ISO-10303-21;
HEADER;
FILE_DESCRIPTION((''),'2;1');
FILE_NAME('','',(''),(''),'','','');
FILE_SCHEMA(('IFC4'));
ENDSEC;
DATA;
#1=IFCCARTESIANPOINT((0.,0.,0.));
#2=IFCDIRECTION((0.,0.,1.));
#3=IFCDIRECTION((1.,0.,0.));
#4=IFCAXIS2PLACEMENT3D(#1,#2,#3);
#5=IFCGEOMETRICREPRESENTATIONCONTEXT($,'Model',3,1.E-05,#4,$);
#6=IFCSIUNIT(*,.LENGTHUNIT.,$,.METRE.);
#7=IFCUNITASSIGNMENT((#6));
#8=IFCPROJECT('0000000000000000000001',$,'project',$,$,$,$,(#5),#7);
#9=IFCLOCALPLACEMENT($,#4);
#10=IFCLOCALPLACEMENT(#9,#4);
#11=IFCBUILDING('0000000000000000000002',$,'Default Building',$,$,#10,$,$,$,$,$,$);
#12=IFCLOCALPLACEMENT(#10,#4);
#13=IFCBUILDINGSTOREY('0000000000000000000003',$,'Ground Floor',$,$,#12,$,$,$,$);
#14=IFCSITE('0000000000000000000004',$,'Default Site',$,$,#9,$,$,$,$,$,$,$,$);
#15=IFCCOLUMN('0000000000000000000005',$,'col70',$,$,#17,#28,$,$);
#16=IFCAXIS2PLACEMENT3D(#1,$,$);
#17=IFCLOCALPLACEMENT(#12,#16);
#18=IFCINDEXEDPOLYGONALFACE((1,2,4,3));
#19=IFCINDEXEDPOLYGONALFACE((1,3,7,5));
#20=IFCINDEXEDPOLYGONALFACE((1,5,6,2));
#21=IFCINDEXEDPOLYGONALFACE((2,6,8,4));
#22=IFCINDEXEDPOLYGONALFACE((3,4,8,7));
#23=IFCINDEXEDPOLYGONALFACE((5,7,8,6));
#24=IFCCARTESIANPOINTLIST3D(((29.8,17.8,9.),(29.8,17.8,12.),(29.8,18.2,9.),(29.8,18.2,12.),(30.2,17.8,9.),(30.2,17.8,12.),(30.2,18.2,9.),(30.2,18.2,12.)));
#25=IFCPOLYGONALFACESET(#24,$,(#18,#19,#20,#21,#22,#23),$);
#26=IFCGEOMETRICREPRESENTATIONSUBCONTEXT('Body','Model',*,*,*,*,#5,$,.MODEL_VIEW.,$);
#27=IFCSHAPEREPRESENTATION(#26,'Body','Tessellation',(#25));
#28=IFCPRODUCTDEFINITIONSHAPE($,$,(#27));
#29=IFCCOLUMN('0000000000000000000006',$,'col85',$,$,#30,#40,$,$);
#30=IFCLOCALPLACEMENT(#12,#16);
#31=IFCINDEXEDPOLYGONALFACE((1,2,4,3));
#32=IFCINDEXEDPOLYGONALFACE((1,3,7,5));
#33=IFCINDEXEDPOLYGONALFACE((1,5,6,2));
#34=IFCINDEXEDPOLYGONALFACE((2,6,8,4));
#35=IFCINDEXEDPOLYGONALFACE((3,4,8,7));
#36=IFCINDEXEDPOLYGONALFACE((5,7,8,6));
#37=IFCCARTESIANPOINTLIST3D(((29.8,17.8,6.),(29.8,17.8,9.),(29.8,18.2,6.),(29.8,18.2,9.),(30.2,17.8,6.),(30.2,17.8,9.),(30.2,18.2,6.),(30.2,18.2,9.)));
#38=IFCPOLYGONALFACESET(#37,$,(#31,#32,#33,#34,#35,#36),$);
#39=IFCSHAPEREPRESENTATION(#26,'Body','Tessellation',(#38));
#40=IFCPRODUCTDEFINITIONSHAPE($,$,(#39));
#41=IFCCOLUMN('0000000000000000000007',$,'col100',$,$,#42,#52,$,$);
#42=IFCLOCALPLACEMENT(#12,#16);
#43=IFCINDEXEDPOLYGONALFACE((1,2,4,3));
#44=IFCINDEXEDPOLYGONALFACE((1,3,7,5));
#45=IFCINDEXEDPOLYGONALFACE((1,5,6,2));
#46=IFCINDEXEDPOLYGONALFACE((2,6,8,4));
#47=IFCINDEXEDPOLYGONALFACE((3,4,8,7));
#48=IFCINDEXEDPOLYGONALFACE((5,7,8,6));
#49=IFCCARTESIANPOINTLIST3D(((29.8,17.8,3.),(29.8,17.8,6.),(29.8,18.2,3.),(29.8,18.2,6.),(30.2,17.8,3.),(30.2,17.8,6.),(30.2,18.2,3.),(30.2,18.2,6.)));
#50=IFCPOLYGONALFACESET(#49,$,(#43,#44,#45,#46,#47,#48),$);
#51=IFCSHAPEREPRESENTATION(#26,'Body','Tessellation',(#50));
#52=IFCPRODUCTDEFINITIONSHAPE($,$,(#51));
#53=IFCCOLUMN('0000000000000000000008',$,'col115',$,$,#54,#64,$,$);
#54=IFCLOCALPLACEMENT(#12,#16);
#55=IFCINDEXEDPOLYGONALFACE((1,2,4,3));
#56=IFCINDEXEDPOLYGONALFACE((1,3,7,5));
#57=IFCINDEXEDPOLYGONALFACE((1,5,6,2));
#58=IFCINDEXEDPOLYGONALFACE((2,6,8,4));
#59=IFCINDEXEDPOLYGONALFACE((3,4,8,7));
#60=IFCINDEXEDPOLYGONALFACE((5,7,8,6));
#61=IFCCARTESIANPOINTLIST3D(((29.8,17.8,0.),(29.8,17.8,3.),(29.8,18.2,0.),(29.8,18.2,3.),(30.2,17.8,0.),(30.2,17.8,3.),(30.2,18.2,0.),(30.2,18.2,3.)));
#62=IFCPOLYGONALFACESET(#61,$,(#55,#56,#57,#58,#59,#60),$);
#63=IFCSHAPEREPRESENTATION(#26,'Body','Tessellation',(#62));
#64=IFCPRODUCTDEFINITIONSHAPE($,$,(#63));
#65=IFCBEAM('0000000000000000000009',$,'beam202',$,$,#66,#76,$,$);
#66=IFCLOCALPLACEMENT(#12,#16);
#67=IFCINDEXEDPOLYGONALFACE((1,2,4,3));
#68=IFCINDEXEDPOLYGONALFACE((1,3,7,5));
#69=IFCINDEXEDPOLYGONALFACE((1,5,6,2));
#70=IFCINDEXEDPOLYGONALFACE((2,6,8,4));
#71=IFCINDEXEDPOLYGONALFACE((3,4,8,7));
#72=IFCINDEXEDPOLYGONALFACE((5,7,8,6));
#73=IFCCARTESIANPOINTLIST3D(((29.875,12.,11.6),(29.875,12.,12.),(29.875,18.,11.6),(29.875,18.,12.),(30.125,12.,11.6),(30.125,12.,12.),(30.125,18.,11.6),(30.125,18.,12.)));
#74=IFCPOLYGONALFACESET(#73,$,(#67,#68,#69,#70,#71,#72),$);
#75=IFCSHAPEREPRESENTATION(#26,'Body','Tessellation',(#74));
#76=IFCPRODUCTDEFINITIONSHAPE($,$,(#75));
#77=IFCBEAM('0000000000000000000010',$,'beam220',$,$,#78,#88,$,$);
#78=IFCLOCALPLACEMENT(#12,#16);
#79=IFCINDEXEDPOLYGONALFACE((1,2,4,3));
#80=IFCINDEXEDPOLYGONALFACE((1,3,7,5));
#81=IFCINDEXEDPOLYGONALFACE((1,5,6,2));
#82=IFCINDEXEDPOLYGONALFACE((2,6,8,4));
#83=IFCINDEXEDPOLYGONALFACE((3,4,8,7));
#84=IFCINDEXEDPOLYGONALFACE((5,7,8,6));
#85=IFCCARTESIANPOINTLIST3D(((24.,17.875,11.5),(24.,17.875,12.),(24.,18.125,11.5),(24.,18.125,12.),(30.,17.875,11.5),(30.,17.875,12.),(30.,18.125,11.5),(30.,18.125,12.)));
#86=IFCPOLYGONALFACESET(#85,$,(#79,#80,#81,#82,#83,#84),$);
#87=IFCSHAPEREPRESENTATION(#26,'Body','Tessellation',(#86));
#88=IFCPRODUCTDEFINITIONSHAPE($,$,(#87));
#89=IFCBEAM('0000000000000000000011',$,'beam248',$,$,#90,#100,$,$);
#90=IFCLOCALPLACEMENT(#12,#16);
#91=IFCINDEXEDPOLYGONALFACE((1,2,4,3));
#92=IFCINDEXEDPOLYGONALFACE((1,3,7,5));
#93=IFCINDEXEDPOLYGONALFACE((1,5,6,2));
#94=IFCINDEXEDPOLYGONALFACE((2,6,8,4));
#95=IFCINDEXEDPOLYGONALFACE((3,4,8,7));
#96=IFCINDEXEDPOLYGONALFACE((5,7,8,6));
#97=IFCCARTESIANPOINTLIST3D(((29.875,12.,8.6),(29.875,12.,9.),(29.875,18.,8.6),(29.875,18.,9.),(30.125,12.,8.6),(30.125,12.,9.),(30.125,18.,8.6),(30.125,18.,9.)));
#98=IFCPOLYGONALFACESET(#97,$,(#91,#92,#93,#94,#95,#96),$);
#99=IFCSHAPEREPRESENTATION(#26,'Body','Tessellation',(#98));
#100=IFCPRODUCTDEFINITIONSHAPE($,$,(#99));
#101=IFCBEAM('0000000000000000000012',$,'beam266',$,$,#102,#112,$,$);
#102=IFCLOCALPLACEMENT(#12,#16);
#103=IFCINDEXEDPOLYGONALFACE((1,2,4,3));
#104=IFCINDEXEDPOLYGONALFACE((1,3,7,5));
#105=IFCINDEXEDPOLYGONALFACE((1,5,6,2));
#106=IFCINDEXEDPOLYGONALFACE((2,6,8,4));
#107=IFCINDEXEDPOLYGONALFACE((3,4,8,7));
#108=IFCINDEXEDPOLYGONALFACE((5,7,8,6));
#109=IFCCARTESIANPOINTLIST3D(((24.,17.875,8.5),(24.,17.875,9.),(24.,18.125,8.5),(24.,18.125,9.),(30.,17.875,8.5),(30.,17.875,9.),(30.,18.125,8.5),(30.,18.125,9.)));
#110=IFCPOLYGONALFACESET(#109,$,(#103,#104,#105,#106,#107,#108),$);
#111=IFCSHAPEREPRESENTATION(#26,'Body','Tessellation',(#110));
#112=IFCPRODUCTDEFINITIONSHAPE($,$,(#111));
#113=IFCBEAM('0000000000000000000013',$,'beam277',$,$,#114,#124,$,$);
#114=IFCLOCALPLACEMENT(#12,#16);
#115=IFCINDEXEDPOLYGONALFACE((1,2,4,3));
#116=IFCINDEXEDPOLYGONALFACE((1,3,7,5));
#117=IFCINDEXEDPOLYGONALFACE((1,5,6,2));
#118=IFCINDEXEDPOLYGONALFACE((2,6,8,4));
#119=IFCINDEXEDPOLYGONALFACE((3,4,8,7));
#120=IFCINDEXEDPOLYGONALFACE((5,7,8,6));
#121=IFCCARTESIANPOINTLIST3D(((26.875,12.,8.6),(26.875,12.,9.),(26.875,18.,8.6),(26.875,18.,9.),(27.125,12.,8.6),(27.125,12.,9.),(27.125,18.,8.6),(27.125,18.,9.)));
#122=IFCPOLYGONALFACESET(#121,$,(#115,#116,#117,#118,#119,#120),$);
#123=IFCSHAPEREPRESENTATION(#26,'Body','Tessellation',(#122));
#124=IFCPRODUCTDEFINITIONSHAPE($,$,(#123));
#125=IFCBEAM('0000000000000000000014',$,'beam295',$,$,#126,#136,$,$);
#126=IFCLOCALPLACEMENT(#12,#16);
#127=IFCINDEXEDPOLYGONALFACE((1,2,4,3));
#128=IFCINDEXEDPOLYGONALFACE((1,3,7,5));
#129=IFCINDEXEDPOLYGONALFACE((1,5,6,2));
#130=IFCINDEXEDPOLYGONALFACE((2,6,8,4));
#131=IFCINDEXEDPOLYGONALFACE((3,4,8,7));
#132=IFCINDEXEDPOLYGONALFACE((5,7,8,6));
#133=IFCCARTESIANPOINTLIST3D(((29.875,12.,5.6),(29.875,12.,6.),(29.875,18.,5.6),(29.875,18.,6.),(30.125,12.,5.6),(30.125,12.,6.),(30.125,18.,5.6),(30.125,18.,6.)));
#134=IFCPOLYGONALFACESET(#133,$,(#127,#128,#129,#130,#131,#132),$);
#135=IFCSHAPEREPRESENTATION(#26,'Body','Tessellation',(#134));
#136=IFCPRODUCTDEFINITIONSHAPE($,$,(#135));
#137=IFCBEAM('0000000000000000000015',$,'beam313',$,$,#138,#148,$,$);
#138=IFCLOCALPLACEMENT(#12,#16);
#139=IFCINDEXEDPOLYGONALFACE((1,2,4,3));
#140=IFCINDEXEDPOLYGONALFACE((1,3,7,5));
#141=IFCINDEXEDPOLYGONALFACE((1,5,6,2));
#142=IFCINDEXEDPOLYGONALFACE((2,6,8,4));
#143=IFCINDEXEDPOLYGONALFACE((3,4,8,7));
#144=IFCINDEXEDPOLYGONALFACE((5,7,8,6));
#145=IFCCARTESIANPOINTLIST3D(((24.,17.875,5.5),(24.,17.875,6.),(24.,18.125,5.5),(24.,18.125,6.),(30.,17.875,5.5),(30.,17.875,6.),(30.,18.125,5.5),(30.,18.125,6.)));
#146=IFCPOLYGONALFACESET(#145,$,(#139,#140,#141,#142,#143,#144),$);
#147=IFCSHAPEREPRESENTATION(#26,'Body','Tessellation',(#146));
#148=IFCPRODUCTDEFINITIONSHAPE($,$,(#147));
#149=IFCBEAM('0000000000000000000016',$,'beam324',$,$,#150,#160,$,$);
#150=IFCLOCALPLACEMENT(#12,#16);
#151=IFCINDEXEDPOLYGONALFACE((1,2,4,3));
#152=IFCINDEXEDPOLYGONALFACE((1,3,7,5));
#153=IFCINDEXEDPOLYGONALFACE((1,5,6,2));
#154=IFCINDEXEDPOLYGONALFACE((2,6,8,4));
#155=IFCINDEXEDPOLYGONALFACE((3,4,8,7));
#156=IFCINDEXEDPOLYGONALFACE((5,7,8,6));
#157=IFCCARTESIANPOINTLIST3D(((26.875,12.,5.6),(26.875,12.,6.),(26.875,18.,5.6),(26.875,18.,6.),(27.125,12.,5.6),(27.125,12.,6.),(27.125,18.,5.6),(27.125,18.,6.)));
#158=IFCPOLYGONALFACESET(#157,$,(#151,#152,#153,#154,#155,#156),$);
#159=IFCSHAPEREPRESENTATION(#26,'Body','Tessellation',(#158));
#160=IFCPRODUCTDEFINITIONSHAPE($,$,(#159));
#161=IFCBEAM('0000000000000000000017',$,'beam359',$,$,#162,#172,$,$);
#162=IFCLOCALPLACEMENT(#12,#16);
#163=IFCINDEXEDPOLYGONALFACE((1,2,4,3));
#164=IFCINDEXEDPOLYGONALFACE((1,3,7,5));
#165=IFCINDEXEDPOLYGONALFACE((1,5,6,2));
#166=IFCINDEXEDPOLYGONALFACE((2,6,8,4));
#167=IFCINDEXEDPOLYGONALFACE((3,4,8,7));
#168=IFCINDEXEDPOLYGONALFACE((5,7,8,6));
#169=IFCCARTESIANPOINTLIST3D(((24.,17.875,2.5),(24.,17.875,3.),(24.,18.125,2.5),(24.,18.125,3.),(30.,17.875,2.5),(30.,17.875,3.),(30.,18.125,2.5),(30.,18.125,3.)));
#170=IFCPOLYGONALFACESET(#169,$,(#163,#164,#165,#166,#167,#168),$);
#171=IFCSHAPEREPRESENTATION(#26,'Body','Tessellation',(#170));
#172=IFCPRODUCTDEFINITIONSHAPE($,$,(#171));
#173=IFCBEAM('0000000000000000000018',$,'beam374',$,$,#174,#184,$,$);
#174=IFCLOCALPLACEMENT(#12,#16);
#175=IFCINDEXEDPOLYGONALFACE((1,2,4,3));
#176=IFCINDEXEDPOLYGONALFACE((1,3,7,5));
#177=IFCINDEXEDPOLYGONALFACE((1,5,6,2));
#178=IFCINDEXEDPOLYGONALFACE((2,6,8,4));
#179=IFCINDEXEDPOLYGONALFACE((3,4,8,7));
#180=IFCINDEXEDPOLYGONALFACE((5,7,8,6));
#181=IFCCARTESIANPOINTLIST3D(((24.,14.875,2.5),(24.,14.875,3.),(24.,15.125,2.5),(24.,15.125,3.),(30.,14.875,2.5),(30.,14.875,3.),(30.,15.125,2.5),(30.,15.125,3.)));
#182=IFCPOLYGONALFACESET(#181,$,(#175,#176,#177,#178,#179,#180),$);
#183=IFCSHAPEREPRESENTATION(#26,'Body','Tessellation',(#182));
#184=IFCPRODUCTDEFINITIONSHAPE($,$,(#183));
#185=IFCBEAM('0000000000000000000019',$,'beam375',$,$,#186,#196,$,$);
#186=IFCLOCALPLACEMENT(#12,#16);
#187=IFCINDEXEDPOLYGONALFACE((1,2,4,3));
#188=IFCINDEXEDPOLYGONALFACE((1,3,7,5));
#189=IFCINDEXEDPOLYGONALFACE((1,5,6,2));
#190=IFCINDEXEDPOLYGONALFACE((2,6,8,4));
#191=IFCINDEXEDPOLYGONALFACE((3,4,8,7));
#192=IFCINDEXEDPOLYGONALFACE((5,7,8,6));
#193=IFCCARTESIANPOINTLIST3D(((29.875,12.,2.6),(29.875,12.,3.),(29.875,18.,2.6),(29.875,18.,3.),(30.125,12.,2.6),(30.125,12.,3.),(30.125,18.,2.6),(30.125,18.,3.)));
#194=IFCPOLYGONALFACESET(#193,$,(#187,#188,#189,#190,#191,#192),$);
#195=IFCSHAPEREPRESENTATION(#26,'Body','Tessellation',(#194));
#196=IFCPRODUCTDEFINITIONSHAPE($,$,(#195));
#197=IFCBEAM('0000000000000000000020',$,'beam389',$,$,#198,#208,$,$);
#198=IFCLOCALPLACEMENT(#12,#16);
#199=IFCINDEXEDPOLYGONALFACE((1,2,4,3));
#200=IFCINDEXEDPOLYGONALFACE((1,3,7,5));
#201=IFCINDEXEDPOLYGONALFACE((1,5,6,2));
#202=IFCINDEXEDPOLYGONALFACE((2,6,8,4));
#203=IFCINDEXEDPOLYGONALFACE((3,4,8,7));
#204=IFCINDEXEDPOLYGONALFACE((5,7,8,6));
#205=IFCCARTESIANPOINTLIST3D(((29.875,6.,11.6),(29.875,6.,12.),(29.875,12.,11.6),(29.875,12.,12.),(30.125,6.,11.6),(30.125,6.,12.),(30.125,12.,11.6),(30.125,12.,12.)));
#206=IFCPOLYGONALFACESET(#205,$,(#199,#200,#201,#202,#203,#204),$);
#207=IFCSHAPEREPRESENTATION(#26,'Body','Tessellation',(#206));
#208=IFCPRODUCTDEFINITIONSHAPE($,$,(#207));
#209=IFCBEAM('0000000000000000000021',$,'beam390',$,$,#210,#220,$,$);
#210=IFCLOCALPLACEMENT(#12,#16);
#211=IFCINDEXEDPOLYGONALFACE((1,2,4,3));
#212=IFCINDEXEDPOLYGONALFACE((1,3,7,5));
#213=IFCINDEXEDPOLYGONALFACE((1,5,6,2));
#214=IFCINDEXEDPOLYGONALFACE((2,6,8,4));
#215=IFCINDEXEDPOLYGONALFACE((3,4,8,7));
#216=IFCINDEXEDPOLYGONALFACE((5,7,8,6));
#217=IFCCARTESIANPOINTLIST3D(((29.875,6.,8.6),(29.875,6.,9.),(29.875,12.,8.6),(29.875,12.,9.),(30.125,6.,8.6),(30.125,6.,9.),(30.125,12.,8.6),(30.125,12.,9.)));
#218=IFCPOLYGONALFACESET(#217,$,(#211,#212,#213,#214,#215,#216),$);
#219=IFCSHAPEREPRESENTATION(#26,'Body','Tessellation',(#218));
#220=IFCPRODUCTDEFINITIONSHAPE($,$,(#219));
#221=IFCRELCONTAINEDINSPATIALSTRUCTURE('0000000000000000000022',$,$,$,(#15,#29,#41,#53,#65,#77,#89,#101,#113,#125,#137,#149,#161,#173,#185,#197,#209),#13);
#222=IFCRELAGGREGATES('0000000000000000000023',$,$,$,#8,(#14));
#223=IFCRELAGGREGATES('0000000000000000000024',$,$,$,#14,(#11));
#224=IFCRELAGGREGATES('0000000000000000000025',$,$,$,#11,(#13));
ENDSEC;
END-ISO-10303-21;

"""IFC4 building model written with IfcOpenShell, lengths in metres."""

from ifc_helpers import new_model, si_unit, frame, origin_with_axes, place, context, subcontext, project, spatial, indexed_curve, outline, extrude, element, save


model = new_model("IFC4")

# Units and contexts
model_context = context("Model", 3, precision=1e-05, world=origin_with_axes())
body_context = subcontext(model_context, "Body", "Model", "MODEL_VIEW")
ifc_project = project(units=[si_unit("LENGTHUNIT", "METRE")], contexts=[model_context])

# Site, building, storey
site_placement = place(None, origin_with_axes())
site = spatial("IfcSite", under=ifc_project, at=site_placement, Name="Default Site")
building_placement = place(site_placement, origin_with_axes())
building = spatial("IfcBuilding", under=site, at=building_placement, Name="Default Building")
storey_placement = place(building_placement, origin_with_axes())
storey = spatial("IfcBuildingStorey", under=building, at=storey_placement, Name="Ground Floor")

# Columns
for number, where, z_axis, x_axis, name in (
    (1, (29.8, 17.8, 9.0), (0.0, 0.0, 1.0), (1.0, 0.0, 0.0), "col70"),
    (2, (29.8, 17.8, 6.0), (0.0, 0.0, 1.0), (1.0, 0.0, 0.0), "col85"),
    (3, (29.8, 17.8, 3.0), (0.0, 0.0, 1.0), (1.0, 0.0, 0.0), "col100"),
    (4, (29.8, 17.8, 0.0), (0.0, 0.0, 1.0), (1.0, 0.0, 0.0), "col115"),
):
    element("IfcColumn", number, at=place(storey_placement, frame(where, z_axis=z_axis, x_axis=x_axis)), inside=storey, Name=name, context=body_context, shape_type="SweptSolid", body=[
        extrude(outline(indexed_curve([(0.0, 0.0), (0.0, 0.4), (0.4, 0.4), (0.4, 0.0), (0.0, 0.0)], self_intersect=False)), origin_with_axes(), (0.0, 0.0, 1.0), 3.0),
    ])

# Beams
beam_1_placement = place(storey_placement, frame((30.125, 12.0, 11.6), z_axis=(0.0, 0.0, 1.0), x_axis=(0.0, 1.0, 0.0)))
element("IfcBeam", 5, at=beam_1_placement, inside=storey, Name="beam202", context=body_context, shape_type="SweptSolid", body=[
    extrude(outline(indexed_curve([(0.0, 0.0), (0.0, 0.25), (6.0, 0.25), (6.0, 0.0), (0.0, 0.0)], self_intersect=False)), origin_with_axes(), (0.0, 0.0, 1.0), 0.4),
])
beam_2_placement = place(storey_placement, frame((24.0, 17.875, 11.5), z_axis=(0.0, 0.0, 1.0), x_axis=(1.0, 0.0, 0.0)))
element("IfcBeam", 6, at=beam_2_placement, inside=storey, Name="beam220", context=body_context, shape_type="SweptSolid", body=[
    extrude(outline(indexed_curve([(0.0, 0.0), (0.0, 0.25), (6.0, 0.25), (6.0, 0.0), (0.0, 0.0)], self_intersect=False)), origin_with_axes(), (0.0, 0.0, 1.0), 0.5),
])
beam_3_placement = place(storey_placement, frame((30.125, 12.0, 8.6), z_axis=(0.0, 0.0, 1.0), x_axis=(0.0, 1.0, 0.0)))
element("IfcBeam", 7, at=beam_3_placement, inside=storey, Name="beam248", context=body_context, shape_type="SweptSolid", body=[
    extrude(outline(indexed_curve([(0.0, 0.0), (0.0, 0.25), (6.0, 0.25), (6.0, 0.0), (0.0, 0.0)], self_intersect=False)), origin_with_axes(), (0.0, 0.0, 1.0), 0.4),
])
beam_4_placement = place(storey_placement, frame((24.0, 17.875, 8.5), z_axis=(0.0, 0.0, 1.0), x_axis=(1.0, 0.0, 0.0)))
element("IfcBeam", 8, at=beam_4_placement, inside=storey, Name="beam266", context=body_context, shape_type="SweptSolid", body=[
    extrude(outline(indexed_curve([(0.0, 0.0), (0.0, 0.25), (6.0, 0.25), (6.0, 0.0), (0.0, 0.0)], self_intersect=False)), origin_with_axes(), (0.0, 0.0, 1.0), 0.5),
])
for number, where, z_axis, x_axis, name in (
    (9, (26.875, 18.0, 8.6), (0.0, 0.0, 1.0), (0.0, -1.0, 0.0), "beam277"),
    (10, (30.125, 12.0, 5.6), (0.0, 0.0, 1.0), (0.0, 1.0, 0.0), "beam295"),
):
    element("IfcBeam", number, at=place(storey_placement, frame(where, z_axis=z_axis, x_axis=x_axis)), inside=storey, Name=name, context=body_context, shape_type="SweptSolid", body=[
        extrude(outline(indexed_curve([(0.0, 0.0), (0.0, 0.25), (6.0, 0.25), (6.0, 0.0), (0.0, 0.0)], self_intersect=False)), origin_with_axes(), (0.0, 0.0, 1.0), 0.4),
    ])
beam_5_placement = place(storey_placement, frame((24.0, 17.875, 5.5), z_axis=(0.0, 0.0, 1.0), x_axis=(1.0, 0.0, 0.0)))
element("IfcBeam", 11, at=beam_5_placement, inside=storey, Name="beam313", context=body_context, shape_type="SweptSolid", body=[
    extrude(outline(indexed_curve([(0.0, 0.0), (0.0, 0.25), (6.0, 0.25), (6.0, 0.0), (0.0, 0.0)], self_intersect=False)), origin_with_axes(), (0.0, 0.0, 1.0), 0.5),
])
beam_6_placement = place(storey_placement, frame((26.875, 18.0, 5.6), z_axis=(0.0, 0.0, 1.0), x_axis=(0.0, -1.0, 0.0)))
element("IfcBeam", 12, at=beam_6_placement, inside=storey, Name="beam324", context=body_context, shape_type="SweptSolid", body=[
    extrude(outline(indexed_curve([(0.0, 0.0), (0.0, 0.25), (6.0, 0.25), (6.0, 0.0), (0.0, 0.0)], self_intersect=False)), origin_with_axes(), (0.0, 0.0, 1.0), 0.4),
])
for number, where, z_axis, x_axis, name in (
    (13, (24.0, 17.875, 2.5), (0.0, 0.0, 1.0), (1.0, 0.0, 0.0), "beam359"),
    (14, (24.0, 14.875, 2.5), (0.0, 0.0, 1.0), (1.0, 0.0, 0.0), "beam374"),
):
    element("IfcBeam", number, at=place(storey_placement, frame(where, z_axis=z_axis, x_axis=x_axis)), inside=storey, Name=name, context=body_context, shape_type="SweptSolid", body=[
        extrude(outline(indexed_curve([(0.0, 0.0), (0.0, 0.25), (6.0, 0.25), (6.0, 0.0), (0.0, 0.0)], self_intersect=False)), origin_with_axes(), (0.0, 0.0, 1.0), 0.5),
    ])
for number, where, z_axis, x_axis, name in (
    (15, (29.875, 18.0, 2.6), (0.0, 0.0, 1.0), (0.0, -1.0, 0.0), "beam375"),
    (16, (29.875, 12.0, 11.6), (0.0, 0.0, 1.0), (0.0, -1.0, 0.0), "beam389"),
    (17, (29.875, 12.0, 8.6), (0.0, 0.0, 1.0), (0.0, -1.0, 0.0), "beam390"),
):
    element("IfcBeam", number, at=place(storey_placement, frame(where, z_axis=z_axis, x_axis=x_axis)), inside=storey, Name=name, context=body_context, shape_type="SweptSolid", body=[
        extrude(outline(indexed_curve([(0.0, 0.0), (0.0, 0.25), (6.0, 0.25), (6.0, 0.0), (0.0, 0.0)], self_intersect=False)), origin_with_axes(), (0.0, 0.0, 1.0), 0.4),
    ])

save(model, "model.ifc")
